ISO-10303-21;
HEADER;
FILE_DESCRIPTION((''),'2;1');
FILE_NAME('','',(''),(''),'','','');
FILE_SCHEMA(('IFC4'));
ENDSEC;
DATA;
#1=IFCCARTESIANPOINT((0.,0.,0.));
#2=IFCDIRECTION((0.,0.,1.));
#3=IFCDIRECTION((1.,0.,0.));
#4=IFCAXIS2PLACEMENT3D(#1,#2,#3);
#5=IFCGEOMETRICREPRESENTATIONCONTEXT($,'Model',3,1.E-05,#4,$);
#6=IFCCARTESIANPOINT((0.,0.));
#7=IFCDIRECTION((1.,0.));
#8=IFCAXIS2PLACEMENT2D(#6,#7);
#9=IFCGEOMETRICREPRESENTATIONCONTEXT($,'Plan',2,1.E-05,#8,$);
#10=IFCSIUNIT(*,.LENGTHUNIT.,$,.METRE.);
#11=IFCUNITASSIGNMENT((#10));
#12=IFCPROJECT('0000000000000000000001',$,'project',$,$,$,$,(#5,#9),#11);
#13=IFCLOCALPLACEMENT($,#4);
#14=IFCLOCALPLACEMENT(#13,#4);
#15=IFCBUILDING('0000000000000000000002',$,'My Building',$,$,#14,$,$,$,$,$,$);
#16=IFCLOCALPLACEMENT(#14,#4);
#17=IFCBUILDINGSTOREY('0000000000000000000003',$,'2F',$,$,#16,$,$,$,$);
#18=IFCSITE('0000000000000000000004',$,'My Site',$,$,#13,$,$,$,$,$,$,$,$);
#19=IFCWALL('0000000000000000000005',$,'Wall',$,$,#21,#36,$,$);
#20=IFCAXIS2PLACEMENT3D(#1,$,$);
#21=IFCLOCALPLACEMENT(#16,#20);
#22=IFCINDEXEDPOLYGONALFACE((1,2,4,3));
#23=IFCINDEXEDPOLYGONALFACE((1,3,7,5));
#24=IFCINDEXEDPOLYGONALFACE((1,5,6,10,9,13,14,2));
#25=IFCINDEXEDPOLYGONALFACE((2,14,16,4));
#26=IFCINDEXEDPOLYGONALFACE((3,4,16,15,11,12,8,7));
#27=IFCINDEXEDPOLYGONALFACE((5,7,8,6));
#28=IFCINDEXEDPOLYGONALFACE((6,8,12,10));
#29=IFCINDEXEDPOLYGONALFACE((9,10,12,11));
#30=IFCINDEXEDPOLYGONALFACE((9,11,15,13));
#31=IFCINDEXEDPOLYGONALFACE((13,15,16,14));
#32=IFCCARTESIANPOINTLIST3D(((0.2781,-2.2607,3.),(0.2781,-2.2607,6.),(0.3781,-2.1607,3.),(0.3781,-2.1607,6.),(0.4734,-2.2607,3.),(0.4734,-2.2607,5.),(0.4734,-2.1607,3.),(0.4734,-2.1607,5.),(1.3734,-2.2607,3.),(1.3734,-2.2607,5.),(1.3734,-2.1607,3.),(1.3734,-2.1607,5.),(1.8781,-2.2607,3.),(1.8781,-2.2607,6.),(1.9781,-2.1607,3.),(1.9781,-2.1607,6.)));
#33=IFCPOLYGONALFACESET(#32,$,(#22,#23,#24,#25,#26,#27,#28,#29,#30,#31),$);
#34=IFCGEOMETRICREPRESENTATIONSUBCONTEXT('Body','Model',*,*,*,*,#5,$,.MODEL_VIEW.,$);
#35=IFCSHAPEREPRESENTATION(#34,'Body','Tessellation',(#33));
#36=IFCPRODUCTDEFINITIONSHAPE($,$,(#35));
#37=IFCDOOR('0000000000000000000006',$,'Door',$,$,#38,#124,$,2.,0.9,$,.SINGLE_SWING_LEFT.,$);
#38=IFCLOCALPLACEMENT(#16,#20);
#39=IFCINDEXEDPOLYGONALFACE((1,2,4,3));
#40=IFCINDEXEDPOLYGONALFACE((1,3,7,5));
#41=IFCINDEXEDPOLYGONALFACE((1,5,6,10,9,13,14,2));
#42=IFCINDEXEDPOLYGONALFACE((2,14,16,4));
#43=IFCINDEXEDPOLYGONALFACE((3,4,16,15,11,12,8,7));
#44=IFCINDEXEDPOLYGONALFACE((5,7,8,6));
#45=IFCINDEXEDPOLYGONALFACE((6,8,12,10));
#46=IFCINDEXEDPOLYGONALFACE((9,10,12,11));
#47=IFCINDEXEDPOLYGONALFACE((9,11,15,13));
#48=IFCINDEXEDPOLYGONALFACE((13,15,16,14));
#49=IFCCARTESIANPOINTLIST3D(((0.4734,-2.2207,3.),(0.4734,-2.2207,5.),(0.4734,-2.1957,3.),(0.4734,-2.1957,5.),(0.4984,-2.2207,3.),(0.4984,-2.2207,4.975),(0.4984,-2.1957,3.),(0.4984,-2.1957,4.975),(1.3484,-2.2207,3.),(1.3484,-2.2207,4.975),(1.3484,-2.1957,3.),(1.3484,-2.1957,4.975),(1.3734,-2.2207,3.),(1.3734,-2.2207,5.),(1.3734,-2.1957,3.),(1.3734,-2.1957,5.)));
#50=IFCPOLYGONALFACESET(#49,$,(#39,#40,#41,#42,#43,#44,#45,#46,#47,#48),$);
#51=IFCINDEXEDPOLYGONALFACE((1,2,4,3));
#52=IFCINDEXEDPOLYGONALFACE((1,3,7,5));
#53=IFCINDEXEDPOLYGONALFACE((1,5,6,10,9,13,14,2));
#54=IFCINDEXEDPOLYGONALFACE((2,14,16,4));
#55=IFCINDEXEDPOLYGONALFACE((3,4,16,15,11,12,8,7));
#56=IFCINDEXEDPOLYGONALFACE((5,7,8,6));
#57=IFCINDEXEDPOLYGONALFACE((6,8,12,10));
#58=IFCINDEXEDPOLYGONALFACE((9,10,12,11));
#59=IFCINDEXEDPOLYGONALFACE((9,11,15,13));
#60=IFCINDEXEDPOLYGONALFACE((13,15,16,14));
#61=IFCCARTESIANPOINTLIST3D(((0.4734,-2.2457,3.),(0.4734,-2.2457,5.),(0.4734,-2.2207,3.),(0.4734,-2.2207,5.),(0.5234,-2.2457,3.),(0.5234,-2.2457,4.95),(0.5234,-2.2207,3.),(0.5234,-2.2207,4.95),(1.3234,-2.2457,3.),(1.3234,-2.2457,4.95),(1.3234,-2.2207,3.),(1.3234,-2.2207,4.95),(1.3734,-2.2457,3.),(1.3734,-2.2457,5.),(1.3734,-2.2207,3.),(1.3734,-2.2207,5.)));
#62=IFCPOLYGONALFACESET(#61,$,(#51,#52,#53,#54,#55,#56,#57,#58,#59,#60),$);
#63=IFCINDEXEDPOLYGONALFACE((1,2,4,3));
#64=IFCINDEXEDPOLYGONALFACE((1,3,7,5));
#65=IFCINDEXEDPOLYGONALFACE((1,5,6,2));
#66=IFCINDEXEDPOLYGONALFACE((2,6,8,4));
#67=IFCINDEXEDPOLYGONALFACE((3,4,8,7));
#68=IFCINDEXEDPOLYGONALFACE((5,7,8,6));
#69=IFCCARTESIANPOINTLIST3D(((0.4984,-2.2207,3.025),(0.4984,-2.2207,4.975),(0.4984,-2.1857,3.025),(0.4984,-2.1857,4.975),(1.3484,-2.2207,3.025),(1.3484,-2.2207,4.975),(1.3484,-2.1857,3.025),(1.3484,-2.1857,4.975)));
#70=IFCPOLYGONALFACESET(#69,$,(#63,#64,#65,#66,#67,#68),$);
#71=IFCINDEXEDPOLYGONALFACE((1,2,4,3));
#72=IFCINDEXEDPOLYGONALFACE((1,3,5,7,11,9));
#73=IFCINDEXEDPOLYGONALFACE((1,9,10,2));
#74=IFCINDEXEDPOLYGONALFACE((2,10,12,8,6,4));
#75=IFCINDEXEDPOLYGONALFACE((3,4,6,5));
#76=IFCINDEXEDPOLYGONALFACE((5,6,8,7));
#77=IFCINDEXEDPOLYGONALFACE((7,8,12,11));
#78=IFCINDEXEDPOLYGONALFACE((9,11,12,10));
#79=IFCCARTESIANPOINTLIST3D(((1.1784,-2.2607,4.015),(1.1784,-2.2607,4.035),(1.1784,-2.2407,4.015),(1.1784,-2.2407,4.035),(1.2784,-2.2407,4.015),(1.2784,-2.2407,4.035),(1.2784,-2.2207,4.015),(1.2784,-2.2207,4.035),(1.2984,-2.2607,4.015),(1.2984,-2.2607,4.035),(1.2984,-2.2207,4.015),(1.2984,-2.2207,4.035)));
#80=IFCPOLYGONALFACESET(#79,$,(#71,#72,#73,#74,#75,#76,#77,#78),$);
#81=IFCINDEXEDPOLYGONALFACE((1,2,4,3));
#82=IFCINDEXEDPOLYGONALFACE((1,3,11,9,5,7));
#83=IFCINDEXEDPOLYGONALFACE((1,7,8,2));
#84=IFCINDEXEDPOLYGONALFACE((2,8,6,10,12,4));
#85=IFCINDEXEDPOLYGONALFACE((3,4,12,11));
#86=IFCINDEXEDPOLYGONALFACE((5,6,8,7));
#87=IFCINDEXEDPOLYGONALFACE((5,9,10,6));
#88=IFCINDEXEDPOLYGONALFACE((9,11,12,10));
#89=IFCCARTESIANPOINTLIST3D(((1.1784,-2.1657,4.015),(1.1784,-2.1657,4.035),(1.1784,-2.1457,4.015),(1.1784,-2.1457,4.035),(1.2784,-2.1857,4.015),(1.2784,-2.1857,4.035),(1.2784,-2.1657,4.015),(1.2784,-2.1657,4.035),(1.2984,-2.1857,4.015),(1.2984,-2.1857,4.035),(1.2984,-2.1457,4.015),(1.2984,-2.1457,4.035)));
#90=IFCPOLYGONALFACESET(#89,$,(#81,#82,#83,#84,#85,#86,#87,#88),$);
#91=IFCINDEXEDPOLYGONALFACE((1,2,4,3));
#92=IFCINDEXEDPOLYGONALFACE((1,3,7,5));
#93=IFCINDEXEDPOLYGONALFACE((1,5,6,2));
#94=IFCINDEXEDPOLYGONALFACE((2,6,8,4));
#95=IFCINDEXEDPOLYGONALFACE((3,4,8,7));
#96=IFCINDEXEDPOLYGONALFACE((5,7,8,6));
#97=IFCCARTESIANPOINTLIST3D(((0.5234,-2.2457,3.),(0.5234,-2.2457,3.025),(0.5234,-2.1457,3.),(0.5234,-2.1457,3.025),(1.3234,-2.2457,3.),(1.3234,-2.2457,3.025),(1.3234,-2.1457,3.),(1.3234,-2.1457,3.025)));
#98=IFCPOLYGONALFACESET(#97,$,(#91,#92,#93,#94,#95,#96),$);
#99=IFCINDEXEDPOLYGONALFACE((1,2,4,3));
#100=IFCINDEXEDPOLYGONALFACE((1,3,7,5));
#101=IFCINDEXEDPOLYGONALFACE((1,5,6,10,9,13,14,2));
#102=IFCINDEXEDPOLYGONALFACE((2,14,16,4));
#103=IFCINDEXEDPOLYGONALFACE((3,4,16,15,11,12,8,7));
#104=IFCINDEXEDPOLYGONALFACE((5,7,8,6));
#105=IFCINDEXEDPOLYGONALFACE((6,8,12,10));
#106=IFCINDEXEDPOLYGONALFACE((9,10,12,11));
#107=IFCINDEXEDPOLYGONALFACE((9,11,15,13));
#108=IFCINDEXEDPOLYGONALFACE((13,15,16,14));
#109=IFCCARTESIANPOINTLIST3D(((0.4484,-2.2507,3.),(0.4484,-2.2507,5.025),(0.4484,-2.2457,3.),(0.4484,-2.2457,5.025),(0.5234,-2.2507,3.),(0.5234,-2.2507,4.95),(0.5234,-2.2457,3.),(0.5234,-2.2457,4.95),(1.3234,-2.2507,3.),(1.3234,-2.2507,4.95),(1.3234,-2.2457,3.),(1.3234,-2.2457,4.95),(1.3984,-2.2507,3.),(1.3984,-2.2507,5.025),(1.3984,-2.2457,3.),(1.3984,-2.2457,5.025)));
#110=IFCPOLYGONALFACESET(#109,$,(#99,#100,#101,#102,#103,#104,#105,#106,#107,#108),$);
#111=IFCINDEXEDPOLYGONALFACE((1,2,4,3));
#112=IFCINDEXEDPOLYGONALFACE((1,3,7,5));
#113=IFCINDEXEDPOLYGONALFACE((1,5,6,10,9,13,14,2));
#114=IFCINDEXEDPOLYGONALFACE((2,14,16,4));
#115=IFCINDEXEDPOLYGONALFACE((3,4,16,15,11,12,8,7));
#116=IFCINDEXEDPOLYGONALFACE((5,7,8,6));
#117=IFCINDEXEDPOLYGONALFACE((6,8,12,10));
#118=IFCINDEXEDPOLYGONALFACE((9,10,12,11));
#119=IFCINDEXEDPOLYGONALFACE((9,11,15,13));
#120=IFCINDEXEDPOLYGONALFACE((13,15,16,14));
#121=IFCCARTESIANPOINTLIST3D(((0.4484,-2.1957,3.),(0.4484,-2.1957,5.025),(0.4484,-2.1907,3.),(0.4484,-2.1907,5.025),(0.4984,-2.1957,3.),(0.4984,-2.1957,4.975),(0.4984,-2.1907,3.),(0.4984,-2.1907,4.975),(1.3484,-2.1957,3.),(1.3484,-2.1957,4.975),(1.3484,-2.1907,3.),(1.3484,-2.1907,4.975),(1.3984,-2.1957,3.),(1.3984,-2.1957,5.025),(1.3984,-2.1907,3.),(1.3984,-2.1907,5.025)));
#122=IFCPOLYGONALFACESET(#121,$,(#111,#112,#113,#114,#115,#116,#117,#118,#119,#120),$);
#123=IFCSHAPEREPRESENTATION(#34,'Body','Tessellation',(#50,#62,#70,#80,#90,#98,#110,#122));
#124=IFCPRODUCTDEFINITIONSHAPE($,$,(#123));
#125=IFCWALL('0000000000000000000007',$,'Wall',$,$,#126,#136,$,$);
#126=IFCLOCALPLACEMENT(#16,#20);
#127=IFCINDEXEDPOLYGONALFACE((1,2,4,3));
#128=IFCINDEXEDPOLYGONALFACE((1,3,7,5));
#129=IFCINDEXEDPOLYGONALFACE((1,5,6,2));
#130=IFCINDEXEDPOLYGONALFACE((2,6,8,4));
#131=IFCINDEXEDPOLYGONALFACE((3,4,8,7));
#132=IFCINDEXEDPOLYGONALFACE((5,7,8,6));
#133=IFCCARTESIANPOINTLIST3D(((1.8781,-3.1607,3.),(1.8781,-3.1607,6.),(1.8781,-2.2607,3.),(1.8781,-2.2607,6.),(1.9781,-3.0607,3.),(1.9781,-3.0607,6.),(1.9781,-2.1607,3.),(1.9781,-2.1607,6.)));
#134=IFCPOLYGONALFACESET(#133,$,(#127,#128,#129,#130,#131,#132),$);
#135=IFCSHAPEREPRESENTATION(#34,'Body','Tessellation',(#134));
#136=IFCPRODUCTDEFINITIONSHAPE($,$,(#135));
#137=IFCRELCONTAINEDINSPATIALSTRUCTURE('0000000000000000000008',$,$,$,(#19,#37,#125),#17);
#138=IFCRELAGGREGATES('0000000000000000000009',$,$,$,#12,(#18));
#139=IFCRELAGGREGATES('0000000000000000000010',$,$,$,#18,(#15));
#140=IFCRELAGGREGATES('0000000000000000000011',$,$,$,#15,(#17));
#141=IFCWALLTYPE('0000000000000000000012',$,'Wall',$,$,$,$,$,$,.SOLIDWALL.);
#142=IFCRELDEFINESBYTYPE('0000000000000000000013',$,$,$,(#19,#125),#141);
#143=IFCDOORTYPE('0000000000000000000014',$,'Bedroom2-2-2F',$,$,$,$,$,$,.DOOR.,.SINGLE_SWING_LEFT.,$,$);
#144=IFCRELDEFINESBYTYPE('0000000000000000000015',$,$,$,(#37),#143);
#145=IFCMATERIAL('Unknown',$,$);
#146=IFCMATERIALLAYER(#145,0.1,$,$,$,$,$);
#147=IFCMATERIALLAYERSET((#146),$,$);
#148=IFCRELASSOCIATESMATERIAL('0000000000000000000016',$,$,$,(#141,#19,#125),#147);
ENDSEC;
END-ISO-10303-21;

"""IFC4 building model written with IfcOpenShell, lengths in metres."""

from ifc_helpers import new_model, entity, si_unit, frame, origin_with_axes, origin_2d_with_axis, place, context, subcontext, project, spatial, line, indexed_curve, outline, extrude, shape, source, transform, mapped, material, layer, layer_set, layer_usage, type_object, type_shapes, element, fill, save


model = new_model("IFC4")

# Units and contexts
model_context = context("Model", 3, precision=1e-05, world=origin_with_axes())
plan_context = context("Plan", 2, precision=1e-05, world=origin_2d_with_axis())
body_context_1 = subcontext(model_context, "Body", "Model", "MODEL_VIEW")
body_context_2 = subcontext(plan_context, "Body", "Plan", "PLAN_VIEW")
ifc_project = project(units=[si_unit("LENGTHUNIT", "METRE")], contexts=[model_context, plan_context])

# Site, building, storey
site_placement = place(None, origin_with_axes())
site = spatial("IfcSite", under=ifc_project, at=site_placement, Name="My Site")
building_placement = place(site_placement, origin_with_axes())
building = spatial("IfcBuilding", under=site, at=building_placement, Name="My Building")
storey_placement = place(building_placement, origin_with_axes())
storey = spatial("IfcBuildingStorey", under=building, at=storey_placement, Name="2F")

# Shared definitions
ifc_material = material(Name="Unknown")

# Shared definitions
ifc_layer = layer(ifc_material, 0.1)
ifc_layer_set = layer_set([ifc_layer])
wall_type = type_object("IfcWallType", Name="Wall", PredefinedType="SOLIDWALL", material=ifc_layer_set)

# Wall, opening, door
ifc_layer_usage_1 = layer_usage(ifc_layer_set, "AXIS2", "POSITIVE", 0.0)
wall_1_placement = place(storey_placement, frame((0.2781, -2.2607, 3.0), z_axis=(0.0, 0.0, 1.0), x_axis=(1.0, 0.0, 0.0)))
wall_1 = element("IfcWall", 1, at=wall_1_placement, inside=storey, type_object=wall_type, material=ifc_layer_usage_1, Name="Wall", context=body_context_1, shape_type="SweptSolid", body=[
    extrude(outline(indexed_curve([(0.0, 0.0), (0.1, 0.1), (1.7, 0.1), (1.6, 0.0)], segments=[line(1, 2, 3, 4, 1)])), origin_with_axes(), (0.0, 0.0, 1.0), 3.0),
])
shared_shape_1 = source(origin_with_axes(), body_context_1, "Body", "SweptSolid", [
    extrude(outline(indexed_curve([(0.0, 0.0), (0.9, 0.0), (0.9, 2.0), (0.0, 2.0)], segments=[line(1, 2, 3, 4, 1)])), frame((0.0, -0.6, 0.0), z_axis=(0.0, -1.0, 0.0), x_axis=(1.0, 0.0, 0.0)), (0.0, 0.0, -1.0), 1.2),
])
opening_1_placement = place(wall_1_placement, frame((0.1952, 0.015, 0.0), z_axis=(0.0, 0.0, 1.0), x_axis=(1.0, 0.0, 0.0)))
opening_1 = element("IfcOpeningElement", 2, at=opening_1_placement, cuts=wall_1, PredefinedType="OPENING", context=body_context_1, shape_type="MappedRepresentation", body=[
    mapped(shared_shape_1, transform((0.0, 0.0, 0.0), x_axis=(1.0, 0.0, 0.0), y_axis=(0.0, 1.0, 0.0), z_axis=(0.0, 0.0, 1.0), scale=1.0)),
])
door_type_1 = type_object("IfcDoorType", Name="Bedroom2-2-2F", OperationType="SINGLE_SWING_LEFT", PredefinedType="DOOR")
shared_shape_2 = source(origin_with_axes(), body_context_1, "Body", "SweptSolid", [
    extrude(outline(indexed_curve([(0.0, 0.0), (0.0, 2.0), (0.9, 2.0), (0.9, 0.0), (0.875, 0.0), (0.875, 1.975), (0.025, 1.975), (0.025, 0.0)], segments=[line(1, 2, 3, 4, 5, 6, 7, 8, 1)])), frame((0.0, 0.025, 0.0), z_axis=(0.0, -1.0, 0.0), x_axis=(1.0, 0.0, 0.0)), (0.0, 0.0, -1.0), 0.025),
    extrude(outline(indexed_curve([(0.0, 0.0), (0.0, 2.0), (0.9, 2.0), (0.9, 0.0), (0.85, 0.0), (0.85, 1.95), (0.05, 1.95), (0.05, 0.0)], segments=[line(1, 2, 3, 4, 5, 6, 7, 8, 1)])), frame((0.0, 0.0, 0.0), z_axis=(0.0, -1.0, 0.0), x_axis=(1.0, 0.0, 0.0)), (0.0, 0.0, -1.0), 0.025),
    extrude(outline(indexed_curve([(0.0, 0.0), (0.85, 0.0), (0.85, 0.035), (0.0, 0.035)], segments=[line(1, 2, 3, 4, 1)])), frame((0.025, 0.025, 0.025), z_axis=(0.0, 0.0, 1.0), x_axis=(1.0, 0.0, 0.0)), (0.0, 0.0, 1.0), 1.95),
    extrude(outline(indexed_curve([(0.0, 0.0), (0.0, -0.04), (-0.12, -0.04), (-0.12, -0.02), (-0.02, -0.02), (-0.02, 0.0)], segments=[line(1, 2, 3, 4, 5, 6, 1)])), frame((0.825, 0.025, 1.015), z_axis=(0.0, 0.0, 1.0), x_axis=(1.0, 0.0, 0.0)), (0.0, 0.0, 1.0), 0.02),
    extrude(outline(indexed_curve([(0.0, 0.0), (0.0, 0.04), (-0.12, 0.04), (-0.12, 0.02), (-0.02, 0.02), (-0.02, 0.0)], segments=[line(1, 2, 3, 4, 5, 6, 1)])), frame((0.825, 0.06, 1.015), z_axis=(0.0, 0.0, 1.0), x_axis=(1.0, 0.0, 0.0)), (0.0, 0.0, 1.0), 0.02),
    extrude(outline(indexed_curve([(0.0, 0.0), (0.8, 0.0), (0.8, 0.1), (0.0, 0.1)], segments=[line(1, 2, 3, 4, 1)])), frame((0.05, 0.0, 0.0), z_axis=(0.0, 0.0, 1.0), x_axis=(1.0, 0.0, 0.0)), (0.0, 0.0, 1.0), 0.025),
    extrude(outline(indexed_curve([(0.0, 0.0), (0.0, 2.025), (0.95, 2.025), (0.95, 0.0), (0.875, 0.0), (0.875, 1.95), (0.075, 1.95), (0.075, 0.0)], segments=[line(1, 2, 3, 4, 5, 6, 7, 8, 1)])), frame((-0.025, -0.005, 0.0), z_axis=(0.0, -1.0, 0.0), x_axis=(1.0, 0.0, 0.0)), (0.0, 0.0, -1.0), 0.005),
    extrude(outline(indexed_curve([(0.0, 0.0), (0.0, 2.025), (0.95, 2.025), (0.95, 0.0), (0.9, 0.0), (0.9, 1.975), (0.05, 1.975), (0.05, 0.0)], segments=[line(1, 2, 3, 4, 5, 6, 7, 8, 1)])), frame((-0.025, 0.05, 0.0), z_axis=(0.0, -1.0, 0.0), x_axis=(1.0, 0.0, 0.0)), (0.0, 0.0, -1.0), 0.005),
])
shared_shape_3 = source(origin_with_axes(), body_context_2, "Body", "Curve2D", [
    entity("IfcIndexedPolyCurve", entity("IfcCartesianPointList2D", [[0.0, 0.0], [0.0, 0.05], [0.025, 0.05], [0.025, 0.025], [0.05, 0.025], [0.05, 0.0]]), [entity("IfcLineIndex", [1, 2, 3, 4, 5, 6, 1])]),
    entity("IfcIndexedPolyCurve", entity("IfcCartesianPointList2D", [[0.9, 0.0], [0.9, 0.05], [0.875, 0.05], [0.875, 0.025], [0.85, 0.025], [0.85, 0.0]]), [entity("IfcLineIndex", [1, 2, 3, 4, 5, 6, 1])]),
    entity("IfcTrimmedCurve", entity("IfcEllipse", entity("IfcAxis2Placement2D", entity("IfcCartesianPoint", [0.06, 0.05]), entity("IfcDirection", [1.0, 0.0])), 0.815, 0.85), [entity("IfcCartesianPoint", [0.875, 0.05])], [entity("IfcCartesianPoint", [0.06, 0.9])], True, "CARTESIAN"),
    entity("IfcIndexedPolyCurve", entity("IfcCartesianPointList2D", [[0.025, 0.05], [0.06, 0.05], [0.06, 0.9], [0.025, 0.9]]), [entity("IfcLineIndex", [1, 2, 3, 4, 1])]),
])
type_shapes(door_type_1, [shared_shape_2, shared_shape_3])
door_1_placement = place(opening_1_placement, frame((0.0, 0.0, 0.0), z_axis=(0.0, 0.0, 1.0), x_axis=(1.0, 0.0, 0.0)))
door_1 = element("IfcDoor", 3, at=door_1_placement, inside=storey, type_object=door_type_1, Name="Door", OperationType="SINGLE_SWING_LEFT", OverallHeight=2.0, OverallWidth=0.9, shapes=[
    shape(body_context_1, "Body", "MappedRepresentation", [mapped(shared_shape_2, transform((0.0, 0.0, 0.0), x_axis=(1.0, 0.0, 0.0), y_axis=(0.0, 1.0, 0.0), z_axis=(0.0, 0.0, 1.0), scale=1.0))]),
    shape(body_context_2, "Body", "MappedRepresentation", [mapped(shared_shape_3, transform((0.0, 0.0, 0.0), x_axis=(1.0, 0.0, 0.0), y_axis=(0.0, 1.0, 0.0), z_axis=(0.0, 0.0, 1.0), scale=1.0))]),
])
fill(opening_1, door_1)

# Wall
ifc_layer_usage_2 = layer_usage(ifc_layer_set, "AXIS2", "POSITIVE", 0.0)
wall_2_placement = place(storey_placement, frame((1.8781, -2.2607, 3.0), z_axis=(0.0, 0.0, 1.0), x_axis=(0.0, -1.0, 0.0)))
element("IfcWall", 4, at=wall_2_placement, inside=storey, type_object=wall_type, material=ifc_layer_usage_2, Name="Wall", context=body_context_1, shape_type="SweptSolid", body=[
    extrude(outline(indexed_curve([(0.0, 0.0), (-0.1, 0.1), (0.8, 0.1), (0.9, 0.0)], segments=[line(1, 2, 3, 4, 1)])), origin_with_axes(), (0.0, 0.0, 1.0), 3.0),
])

save(model, "model.ifc")
